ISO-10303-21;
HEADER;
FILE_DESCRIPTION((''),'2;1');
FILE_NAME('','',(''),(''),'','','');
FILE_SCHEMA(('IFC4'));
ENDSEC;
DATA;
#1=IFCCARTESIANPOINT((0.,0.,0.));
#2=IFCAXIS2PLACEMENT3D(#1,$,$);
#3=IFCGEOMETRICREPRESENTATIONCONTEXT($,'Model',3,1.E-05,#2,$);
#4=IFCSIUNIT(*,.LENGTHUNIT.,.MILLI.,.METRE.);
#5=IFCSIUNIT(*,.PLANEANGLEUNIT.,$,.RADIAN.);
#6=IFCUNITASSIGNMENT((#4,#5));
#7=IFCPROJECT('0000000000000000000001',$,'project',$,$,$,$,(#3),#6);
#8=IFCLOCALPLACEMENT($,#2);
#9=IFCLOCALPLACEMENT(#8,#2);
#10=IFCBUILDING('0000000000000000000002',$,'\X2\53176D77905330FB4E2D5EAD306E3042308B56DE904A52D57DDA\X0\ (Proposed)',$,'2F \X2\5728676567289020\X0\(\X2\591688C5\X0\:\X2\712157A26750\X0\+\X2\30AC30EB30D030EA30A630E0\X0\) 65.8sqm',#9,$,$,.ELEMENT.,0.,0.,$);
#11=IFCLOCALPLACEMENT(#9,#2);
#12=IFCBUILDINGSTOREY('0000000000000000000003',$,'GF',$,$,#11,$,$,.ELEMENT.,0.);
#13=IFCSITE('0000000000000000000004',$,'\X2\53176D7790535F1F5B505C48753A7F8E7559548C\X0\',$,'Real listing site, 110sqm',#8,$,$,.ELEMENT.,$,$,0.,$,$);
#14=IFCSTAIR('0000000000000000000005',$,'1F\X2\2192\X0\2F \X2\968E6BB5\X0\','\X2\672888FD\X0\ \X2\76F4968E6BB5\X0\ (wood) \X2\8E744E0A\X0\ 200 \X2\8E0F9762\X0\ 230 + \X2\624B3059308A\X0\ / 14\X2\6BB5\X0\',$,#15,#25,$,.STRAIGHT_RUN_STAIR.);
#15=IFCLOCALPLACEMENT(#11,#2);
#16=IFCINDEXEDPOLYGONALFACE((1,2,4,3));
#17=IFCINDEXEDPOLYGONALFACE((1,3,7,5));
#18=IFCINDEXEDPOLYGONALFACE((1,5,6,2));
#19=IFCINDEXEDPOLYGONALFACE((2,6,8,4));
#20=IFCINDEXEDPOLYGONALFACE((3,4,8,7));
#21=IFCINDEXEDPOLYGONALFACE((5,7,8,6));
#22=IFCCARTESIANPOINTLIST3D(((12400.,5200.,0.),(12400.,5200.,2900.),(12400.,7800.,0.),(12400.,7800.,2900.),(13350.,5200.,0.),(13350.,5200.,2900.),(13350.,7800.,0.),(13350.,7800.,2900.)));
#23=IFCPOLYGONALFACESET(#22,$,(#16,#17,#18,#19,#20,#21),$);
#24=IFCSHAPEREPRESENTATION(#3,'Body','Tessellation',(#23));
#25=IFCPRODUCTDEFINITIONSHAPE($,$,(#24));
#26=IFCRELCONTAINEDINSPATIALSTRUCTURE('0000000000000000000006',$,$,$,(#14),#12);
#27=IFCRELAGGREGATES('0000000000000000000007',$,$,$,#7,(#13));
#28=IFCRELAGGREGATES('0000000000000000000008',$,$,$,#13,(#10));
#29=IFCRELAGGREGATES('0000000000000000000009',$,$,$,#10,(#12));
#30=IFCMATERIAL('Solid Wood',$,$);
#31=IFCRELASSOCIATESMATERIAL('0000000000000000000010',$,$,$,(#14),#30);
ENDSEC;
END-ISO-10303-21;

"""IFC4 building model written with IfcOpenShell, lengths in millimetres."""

from ifc_helpers import new_model, si_unit, frame, frame_2d, origin, place, context, project, spatial, rectangle, extrude, material, element, save


model = new_model("IFC4")

# Units and contexts
model_context = context("Model", 3, precision=1e-05, world=origin())
ifc_project = project(units=[si_unit("LENGTHUNIT", "METRE", prefix="MILLI"), si_unit("PLANEANGLEUNIT", "RADIAN")], contexts=[model_context])

# Site, building, storey
site_placement = place(None, origin())
site = spatial("IfcSite", under=ifc_project, at=site_placement, Name="北海道弟子屈町美留和", ObjectType="Real listing site, 110sqm", CompositionType="ELEMENT", RefElevation=0.0)
building_placement = place(site_placement, origin())
building = spatial("IfcBuilding", under=site, at=building_placement, Name="北海道・中庭のある回遊動線 (Proposed)", ObjectType="2F 在来木造(外装:無垢材+ガルバリウム) 65.8sqm", CompositionType="ELEMENT", ElevationOfRefHeight=0.0, ElevationOfTerrain=0.0)
storey_placement = place(building_placement, origin())
storey = spatial("IfcBuildingStorey", under=building, at=storey_placement, Name="GF", CompositionType="ELEMENT", Elevation=0.0)

# Shared definitions
ifc_material_1 = material(Name="Solid Wood")

# Stair
stair_placement = place(storey_placement, frame((6200.0, 2600.0, 0.0)))
element("IfcStair", 1, at=stair_placement, inside=storey, material=ifc_material_1, Name="1F→2F 階段", Description="木製 直階段 (wood) 蹴上 200 踏面 230 + 手すり / 14段", PredefinedType="STRAIGHT_RUN_STAIR", context=model_context, shape_type="SweptSolid", body=[
    extrude(rectangle(XDim=950.0, YDim=2600.0, at=frame_2d((475.0, 1300.0))), frame((6200.0, 2600.0, 0.0)), (0.0, 0.0, 1.0), 2900.0),
])

save(model, "model.ifc")
